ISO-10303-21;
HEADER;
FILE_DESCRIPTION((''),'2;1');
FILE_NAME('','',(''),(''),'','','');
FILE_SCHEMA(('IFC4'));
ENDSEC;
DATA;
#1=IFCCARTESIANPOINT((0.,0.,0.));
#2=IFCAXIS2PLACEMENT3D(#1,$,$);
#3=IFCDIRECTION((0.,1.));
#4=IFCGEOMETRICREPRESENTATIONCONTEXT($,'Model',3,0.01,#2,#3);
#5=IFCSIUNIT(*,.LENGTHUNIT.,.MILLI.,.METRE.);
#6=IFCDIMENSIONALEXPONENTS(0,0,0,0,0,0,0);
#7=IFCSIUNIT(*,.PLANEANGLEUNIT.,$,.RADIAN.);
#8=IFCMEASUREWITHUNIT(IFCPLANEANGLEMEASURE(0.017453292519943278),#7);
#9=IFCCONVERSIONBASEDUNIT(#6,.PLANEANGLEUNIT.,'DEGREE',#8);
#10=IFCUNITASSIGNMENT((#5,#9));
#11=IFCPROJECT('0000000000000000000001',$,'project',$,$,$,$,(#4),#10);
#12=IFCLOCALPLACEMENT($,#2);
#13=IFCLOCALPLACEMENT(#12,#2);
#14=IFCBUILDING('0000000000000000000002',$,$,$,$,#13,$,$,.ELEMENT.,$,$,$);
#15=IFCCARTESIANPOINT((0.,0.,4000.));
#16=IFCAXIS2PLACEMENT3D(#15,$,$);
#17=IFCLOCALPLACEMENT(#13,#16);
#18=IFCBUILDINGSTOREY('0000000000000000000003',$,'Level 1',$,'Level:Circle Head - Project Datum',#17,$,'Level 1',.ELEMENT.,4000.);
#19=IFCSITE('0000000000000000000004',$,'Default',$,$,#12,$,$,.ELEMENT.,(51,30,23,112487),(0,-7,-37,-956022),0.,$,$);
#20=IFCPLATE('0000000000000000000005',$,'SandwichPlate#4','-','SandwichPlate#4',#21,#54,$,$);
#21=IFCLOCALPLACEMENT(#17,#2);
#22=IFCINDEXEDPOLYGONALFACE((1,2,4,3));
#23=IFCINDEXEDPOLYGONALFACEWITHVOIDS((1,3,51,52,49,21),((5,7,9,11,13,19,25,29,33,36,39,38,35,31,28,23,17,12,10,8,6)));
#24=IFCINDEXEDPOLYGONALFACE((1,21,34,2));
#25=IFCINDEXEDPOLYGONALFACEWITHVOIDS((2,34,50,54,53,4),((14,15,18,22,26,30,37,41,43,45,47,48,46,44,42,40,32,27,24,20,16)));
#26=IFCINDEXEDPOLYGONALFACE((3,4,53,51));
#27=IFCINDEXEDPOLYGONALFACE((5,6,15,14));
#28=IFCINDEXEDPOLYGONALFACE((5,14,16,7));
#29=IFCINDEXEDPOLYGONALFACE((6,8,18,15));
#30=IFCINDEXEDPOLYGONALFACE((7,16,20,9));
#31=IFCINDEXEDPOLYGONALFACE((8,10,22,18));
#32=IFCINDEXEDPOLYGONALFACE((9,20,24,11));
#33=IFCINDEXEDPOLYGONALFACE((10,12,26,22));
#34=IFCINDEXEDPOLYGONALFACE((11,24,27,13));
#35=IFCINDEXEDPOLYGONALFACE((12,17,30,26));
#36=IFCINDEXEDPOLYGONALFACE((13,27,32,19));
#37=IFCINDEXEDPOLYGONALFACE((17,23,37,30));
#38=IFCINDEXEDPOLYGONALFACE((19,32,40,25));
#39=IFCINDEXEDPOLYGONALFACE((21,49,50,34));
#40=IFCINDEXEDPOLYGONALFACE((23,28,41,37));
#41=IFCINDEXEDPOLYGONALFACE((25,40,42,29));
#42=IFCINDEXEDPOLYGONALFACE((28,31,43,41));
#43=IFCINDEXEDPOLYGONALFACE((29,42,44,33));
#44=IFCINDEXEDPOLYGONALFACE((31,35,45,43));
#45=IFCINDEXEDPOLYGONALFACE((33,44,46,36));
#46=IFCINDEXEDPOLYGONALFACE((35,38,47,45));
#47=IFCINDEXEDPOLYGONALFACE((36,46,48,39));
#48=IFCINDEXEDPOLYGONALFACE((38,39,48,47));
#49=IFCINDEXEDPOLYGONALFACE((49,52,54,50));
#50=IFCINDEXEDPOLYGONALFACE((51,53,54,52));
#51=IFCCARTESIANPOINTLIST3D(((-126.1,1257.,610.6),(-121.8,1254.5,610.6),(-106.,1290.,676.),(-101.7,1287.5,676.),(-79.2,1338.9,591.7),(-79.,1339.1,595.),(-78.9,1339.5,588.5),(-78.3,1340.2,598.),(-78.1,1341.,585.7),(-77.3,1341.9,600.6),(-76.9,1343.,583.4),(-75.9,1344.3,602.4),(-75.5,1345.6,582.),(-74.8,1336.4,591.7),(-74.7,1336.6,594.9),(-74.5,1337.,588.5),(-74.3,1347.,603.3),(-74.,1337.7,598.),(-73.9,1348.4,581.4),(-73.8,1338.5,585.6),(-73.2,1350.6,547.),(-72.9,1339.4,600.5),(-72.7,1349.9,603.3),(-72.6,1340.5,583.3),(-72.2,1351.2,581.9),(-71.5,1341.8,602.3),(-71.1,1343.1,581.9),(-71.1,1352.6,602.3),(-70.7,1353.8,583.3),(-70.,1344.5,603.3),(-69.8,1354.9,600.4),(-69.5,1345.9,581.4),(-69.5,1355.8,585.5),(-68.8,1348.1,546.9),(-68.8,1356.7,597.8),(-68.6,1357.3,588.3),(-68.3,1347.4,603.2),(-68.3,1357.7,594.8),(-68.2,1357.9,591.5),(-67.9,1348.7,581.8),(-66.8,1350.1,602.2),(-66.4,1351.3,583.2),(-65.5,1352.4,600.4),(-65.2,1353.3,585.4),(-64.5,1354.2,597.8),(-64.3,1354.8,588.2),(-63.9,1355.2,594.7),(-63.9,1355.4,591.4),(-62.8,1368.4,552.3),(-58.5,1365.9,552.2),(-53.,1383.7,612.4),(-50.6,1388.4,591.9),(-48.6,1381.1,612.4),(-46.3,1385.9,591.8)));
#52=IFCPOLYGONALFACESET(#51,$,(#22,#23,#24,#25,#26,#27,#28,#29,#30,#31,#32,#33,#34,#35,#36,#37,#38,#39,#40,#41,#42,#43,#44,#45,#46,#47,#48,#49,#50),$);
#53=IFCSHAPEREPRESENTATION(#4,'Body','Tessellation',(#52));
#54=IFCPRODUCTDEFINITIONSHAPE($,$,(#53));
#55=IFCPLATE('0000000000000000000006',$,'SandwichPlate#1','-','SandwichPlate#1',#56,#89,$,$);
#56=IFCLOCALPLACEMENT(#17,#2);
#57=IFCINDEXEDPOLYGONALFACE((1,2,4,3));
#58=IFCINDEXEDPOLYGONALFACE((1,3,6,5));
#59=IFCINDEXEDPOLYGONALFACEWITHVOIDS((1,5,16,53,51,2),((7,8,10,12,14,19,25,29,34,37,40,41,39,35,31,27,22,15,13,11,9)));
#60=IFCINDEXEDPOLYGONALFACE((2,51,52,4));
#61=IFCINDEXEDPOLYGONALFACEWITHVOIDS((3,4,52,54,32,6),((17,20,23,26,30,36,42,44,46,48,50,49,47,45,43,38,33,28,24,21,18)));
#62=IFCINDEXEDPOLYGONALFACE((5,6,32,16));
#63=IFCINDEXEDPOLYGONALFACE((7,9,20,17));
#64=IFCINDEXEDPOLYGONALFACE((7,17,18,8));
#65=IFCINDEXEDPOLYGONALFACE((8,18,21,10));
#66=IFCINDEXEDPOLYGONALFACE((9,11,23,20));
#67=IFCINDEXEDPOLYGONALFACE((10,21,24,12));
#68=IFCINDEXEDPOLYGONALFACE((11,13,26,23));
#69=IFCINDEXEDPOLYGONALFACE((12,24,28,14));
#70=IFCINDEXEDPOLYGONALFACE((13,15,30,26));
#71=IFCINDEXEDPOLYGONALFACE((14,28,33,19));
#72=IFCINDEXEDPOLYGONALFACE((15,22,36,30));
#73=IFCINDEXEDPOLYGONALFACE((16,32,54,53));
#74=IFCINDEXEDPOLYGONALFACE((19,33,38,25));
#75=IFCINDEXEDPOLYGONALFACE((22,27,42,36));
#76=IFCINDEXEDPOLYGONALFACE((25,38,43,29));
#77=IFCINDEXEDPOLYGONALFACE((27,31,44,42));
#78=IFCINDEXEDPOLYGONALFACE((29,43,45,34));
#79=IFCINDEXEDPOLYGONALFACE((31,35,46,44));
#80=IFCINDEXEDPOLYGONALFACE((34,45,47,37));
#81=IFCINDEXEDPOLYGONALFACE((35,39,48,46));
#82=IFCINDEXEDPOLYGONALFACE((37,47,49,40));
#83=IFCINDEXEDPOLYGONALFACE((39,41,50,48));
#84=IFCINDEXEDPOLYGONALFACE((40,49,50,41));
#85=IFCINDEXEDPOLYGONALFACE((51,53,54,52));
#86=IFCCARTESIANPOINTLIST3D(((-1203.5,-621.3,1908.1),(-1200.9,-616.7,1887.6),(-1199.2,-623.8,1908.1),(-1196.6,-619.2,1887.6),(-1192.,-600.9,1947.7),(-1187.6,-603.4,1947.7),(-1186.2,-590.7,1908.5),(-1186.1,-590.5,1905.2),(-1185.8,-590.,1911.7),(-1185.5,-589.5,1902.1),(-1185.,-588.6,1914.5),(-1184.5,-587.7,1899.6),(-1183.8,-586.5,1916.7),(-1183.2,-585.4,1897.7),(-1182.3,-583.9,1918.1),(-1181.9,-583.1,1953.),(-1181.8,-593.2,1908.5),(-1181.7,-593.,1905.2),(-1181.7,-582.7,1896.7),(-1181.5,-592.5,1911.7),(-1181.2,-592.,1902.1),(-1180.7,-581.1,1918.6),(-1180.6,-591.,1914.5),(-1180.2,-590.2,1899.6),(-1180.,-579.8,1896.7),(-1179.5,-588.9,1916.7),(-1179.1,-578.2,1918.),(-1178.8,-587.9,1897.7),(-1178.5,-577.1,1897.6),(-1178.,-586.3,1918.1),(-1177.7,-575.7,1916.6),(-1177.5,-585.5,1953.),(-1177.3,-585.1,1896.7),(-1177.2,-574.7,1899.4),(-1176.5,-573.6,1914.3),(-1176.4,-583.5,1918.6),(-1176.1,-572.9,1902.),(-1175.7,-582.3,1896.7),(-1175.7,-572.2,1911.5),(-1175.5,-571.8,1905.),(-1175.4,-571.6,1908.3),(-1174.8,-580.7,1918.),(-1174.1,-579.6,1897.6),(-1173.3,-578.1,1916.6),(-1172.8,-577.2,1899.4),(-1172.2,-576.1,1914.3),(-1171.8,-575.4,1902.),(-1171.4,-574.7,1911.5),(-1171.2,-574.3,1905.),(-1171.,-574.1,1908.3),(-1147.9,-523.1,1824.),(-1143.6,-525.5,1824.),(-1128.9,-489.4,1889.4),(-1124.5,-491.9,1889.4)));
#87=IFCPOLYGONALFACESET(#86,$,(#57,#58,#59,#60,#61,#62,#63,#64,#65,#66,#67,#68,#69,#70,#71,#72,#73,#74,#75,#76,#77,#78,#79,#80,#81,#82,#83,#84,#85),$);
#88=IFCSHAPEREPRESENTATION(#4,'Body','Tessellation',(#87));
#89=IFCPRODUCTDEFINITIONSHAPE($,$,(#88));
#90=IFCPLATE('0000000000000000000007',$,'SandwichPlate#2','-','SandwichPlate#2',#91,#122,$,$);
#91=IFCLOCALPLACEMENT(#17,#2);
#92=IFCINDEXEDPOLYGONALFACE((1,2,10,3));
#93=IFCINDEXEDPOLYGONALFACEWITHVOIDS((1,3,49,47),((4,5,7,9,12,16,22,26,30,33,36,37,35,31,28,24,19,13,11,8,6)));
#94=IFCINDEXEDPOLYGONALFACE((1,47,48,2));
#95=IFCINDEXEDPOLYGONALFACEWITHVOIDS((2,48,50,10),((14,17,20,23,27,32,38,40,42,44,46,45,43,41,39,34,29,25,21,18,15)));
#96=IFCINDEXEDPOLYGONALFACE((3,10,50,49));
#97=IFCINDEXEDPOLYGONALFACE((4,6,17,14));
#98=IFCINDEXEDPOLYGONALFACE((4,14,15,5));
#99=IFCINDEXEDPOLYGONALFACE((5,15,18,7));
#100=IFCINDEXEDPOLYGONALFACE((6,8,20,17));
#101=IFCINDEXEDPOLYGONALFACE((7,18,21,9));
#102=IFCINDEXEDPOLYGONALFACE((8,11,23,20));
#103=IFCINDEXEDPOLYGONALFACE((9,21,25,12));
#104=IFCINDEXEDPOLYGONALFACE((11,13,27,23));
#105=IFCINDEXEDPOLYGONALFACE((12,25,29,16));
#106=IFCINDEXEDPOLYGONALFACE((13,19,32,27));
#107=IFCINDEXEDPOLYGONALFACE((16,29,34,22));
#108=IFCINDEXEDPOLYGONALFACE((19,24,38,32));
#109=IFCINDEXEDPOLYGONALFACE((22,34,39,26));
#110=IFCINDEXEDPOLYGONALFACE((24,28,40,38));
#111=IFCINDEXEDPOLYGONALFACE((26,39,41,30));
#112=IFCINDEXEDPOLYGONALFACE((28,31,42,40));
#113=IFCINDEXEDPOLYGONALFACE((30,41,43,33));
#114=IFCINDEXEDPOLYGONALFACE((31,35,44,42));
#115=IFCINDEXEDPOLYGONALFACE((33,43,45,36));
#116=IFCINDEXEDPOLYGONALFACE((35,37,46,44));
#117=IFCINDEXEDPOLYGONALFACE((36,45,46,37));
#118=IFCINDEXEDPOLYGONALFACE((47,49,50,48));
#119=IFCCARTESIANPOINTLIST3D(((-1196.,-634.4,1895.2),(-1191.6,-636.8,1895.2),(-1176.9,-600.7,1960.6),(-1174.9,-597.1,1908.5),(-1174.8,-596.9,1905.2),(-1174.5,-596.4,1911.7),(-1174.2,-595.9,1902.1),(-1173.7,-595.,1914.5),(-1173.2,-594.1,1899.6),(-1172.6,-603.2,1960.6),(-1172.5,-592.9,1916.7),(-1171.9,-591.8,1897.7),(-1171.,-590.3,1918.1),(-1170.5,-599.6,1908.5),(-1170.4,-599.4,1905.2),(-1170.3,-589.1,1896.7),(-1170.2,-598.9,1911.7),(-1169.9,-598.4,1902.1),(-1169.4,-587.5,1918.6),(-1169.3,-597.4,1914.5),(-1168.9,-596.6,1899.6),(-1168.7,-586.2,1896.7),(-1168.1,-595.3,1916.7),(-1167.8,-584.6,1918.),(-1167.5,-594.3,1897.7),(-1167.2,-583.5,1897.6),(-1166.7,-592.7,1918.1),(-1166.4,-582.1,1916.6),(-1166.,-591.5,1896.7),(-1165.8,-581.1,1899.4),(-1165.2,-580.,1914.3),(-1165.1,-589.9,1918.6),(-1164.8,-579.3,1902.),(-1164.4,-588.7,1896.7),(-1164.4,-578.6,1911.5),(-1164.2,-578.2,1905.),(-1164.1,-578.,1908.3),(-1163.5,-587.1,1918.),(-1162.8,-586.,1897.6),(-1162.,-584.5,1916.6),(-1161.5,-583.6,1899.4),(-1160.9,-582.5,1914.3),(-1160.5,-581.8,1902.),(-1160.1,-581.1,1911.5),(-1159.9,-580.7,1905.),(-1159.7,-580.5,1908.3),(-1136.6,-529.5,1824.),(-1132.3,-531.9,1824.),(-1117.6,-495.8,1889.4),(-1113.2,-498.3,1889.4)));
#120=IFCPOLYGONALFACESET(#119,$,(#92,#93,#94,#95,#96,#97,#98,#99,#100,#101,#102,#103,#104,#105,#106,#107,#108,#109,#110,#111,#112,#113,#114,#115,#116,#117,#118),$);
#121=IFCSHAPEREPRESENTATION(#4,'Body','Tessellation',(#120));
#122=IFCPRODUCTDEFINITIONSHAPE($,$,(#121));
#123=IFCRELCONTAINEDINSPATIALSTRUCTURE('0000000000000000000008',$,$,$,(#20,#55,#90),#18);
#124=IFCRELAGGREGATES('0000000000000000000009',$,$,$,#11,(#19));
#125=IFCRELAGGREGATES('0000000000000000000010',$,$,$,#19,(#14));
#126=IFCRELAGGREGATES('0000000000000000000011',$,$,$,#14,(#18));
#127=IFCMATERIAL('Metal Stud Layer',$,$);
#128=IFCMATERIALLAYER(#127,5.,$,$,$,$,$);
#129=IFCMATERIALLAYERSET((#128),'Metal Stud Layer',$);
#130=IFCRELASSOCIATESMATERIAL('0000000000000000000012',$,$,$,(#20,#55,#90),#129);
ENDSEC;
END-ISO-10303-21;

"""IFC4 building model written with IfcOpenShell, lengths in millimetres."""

from ifc_helpers import new_model, entity, si_unit, converted_unit, direction, frame, origin, origin_with_axes, origin_2d_with_axis, place, context, project, spatial, polyline, circle, outline, extrude, material, layer, layer_set, element, save


model = new_model("IFC4")

# Units and contexts
model_context = context("Model", 3, precision=0.01, world=origin(), true_north=direction((0.0, 1.0)))
ifc_project = project(units=[si_unit("LENGTHUNIT", "METRE", prefix="MILLI"), converted_unit("PLANEANGLEUNIT", "DEGREE", entity("IfcPlaneAngleMeasure", 0.017453292519943278), si_unit("PLANEANGLEUNIT", "RADIAN"), dimensions=[0, 0, 0, 0, 0, 0, 0])], contexts=[model_context])

# Site, building, storey
site_placement = place(None, origin())
site = spatial("IfcSite", under=ifc_project, at=site_placement, Name="Default", CompositionType="ELEMENT", RefLatitude=(51, 30, 23, 112487), RefLongitude=(0, -7, -37, -956022), RefElevation=0.0)
building_placement = place(site_placement, origin())
building = spatial("IfcBuilding", under=site, at=building_placement, CompositionType="ELEMENT")
storey_placement = place(building_placement, frame((0.0, 0.0, 4000.0)))
storey = spatial("IfcBuildingStorey", under=building, at=storey_placement, Name="Level 1", ObjectType="Level:Circle Head - Project Datum", LongName="Level 1", CompositionType="ELEMENT", Elevation=4000.0)

# Plate, openings
ifc_material_1 = material(Name="Metal Stud Layer")
ifc_layer_1 = layer(ifc_material_1, 5.0)
ifc_layer_set_1 = layer_set([ifc_layer_1], Name="Metal Stud Layer")
plate_1_placement = place(storey_placement, frame((-66.8, 1361.9, 539.4), z_axis=(0.865935, -0.499948, -0.014432), x_axis=(0.265222, 0.434531, 0.86072)))
plate_1 = element("IfcPlate", 1, at=plate_1_placement, inside=storey, material=ifc_layer_set_1, Name="SandwichPlate#4", Description="-", ObjectType="SandwichPlate#4", context=model_context, shape_type="SweptSolid", body=[
    extrude(outline(polyline([(0.0, 0.0), (76.0, 0.0), (76.0, 140.0), (0.0, 140.0), (0.0, 0.0)])), origin_with_axes(), (0.0, 0.0, 1.0), 5.0),
])
opening_1_placement = place(plate_1_placement, frame((0.0, 0.0, 0.0), z_axis=(0.0, 0.0, 1.0), x_axis=(1.0, 0.0, 0.0)))
element("IfcOpeningElement", 2, at=opening_1_placement, cuts=plate_1, ObjectType="Opening", context=model_context, shape_type="SweptSolid", body=[
    extrude(outline(polyline([(0.0, 0.0), (15.0, 0.0), (0.0, 15.0), (0.0, 0.0)])), origin(), (0.0, 0.0, 1.0), 5.0),
])
opening_2_placement = place(plate_1_placement, frame((0.0, 0.0, 0.0), z_axis=(0.0, 0.0, 1.0), x_axis=(1.0, 0.0, 0.0)))
element("IfcOpeningElement", 3, at=opening_2_placement, cuts=plate_1, ObjectType="Opening", context=model_context, shape_type="SweptSolid", body=[
    extrude(outline(polyline([(76.0, 0.0), (76.0, 15.0), (61.0, 0.0), (76.0, 0.0)])), origin(), (0.0, 0.0, 1.0), 5.0),
])
opening_3_placement = place(plate_1_placement, frame((38.0, 40.0, -0.5), z_axis=(0.0, 0.0, 1.0), x_axis=(0.0, 1.0, 0.0)))
element("IfcOpeningElement", 4, at=opening_3_placement, cuts=plate_1, ObjectType="Opening", context=model_context, shape_type="SweptSolid", body=[
    extrude(circle(Radius=11.0, at=origin_2d_with_axis()), origin(), (0.0, 0.0, 1.0), 6.0),
])

# Plates, openings
plate_2_placement = place(storey_placement, frame((-1188.2, -594.3, 1960.6), z_axis=(0.87026, -0.492593, 0.0), x_axis=(-0.250667, -0.442852, -0.860841)))
plate_2 = element("IfcPlate", 5, at=plate_2_placement, inside=storey, material=ifc_layer_set_1, Name="SandwichPlate#1", Description="-", ObjectType="SandwichPlate#1", context=model_context, shape_type="SweptSolid", body=[
    extrude(outline(polyline([(15.0, 0.0), (61.0, 0.0), (76.0, 15.0), (76.0, 140.0), (0.0, 140.0), (0.0, 15.0), (15.0, 0.0)])), origin_with_axes(), (0.0, 0.0, 1.0), 5.0),
])
opening_4_placement = place(plate_2_placement, frame((38.0, 40.0, -0.5), z_axis=(0.0, 0.0, 1.0), x_axis=(0.0, 1.0, 0.0)))
element("IfcOpeningElement", 6, at=opening_4_placement, cuts=plate_2, ObjectType="Opening", context=model_context, shape_type="SweptSolid", body=[
    extrude(circle(Radius=11.0, at=origin_2d_with_axis()), origin(), (0.0, 0.0, 1.0), 6.0),
])
plate_3_placement = place(storey_placement, frame((-1176.9, -600.7, 1960.6), z_axis=(0.87026, -0.492593, 0.0), x_axis=(-0.250667, -0.442852, -0.860841)))
plate_3 = element("IfcPlate", 7, at=plate_3_placement, inside=storey, material=ifc_layer_set_1, Name="SandwichPlate#2", Description="-", ObjectType="SandwichPlate#2", context=model_context, shape_type="SweptSolid", body=[
    extrude(outline(polyline([(0.0, 0.0), (76.0, 0.0), (76.0, 140.0), (0.0, 140.0), (0.0, 0.0)])), origin_with_axes(), (0.0, 0.0, 1.0), 5.0),
])
opening_5_placement = place(plate_3_placement, frame((38.0, 40.0, -0.5), z_axis=(0.0, 0.0, 1.0), x_axis=(0.0, 1.0, 0.0)))
element("IfcOpeningElement", 8, at=opening_5_placement, cuts=plate_3, ObjectType="Opening", context=model_context, shape_type="SweptSolid", body=[
    extrude(circle(Radius=11.0, at=origin_2d_with_axis()), origin(), (0.0, 0.0, 1.0), 6.0),
])

save(model, "model.ifc")
